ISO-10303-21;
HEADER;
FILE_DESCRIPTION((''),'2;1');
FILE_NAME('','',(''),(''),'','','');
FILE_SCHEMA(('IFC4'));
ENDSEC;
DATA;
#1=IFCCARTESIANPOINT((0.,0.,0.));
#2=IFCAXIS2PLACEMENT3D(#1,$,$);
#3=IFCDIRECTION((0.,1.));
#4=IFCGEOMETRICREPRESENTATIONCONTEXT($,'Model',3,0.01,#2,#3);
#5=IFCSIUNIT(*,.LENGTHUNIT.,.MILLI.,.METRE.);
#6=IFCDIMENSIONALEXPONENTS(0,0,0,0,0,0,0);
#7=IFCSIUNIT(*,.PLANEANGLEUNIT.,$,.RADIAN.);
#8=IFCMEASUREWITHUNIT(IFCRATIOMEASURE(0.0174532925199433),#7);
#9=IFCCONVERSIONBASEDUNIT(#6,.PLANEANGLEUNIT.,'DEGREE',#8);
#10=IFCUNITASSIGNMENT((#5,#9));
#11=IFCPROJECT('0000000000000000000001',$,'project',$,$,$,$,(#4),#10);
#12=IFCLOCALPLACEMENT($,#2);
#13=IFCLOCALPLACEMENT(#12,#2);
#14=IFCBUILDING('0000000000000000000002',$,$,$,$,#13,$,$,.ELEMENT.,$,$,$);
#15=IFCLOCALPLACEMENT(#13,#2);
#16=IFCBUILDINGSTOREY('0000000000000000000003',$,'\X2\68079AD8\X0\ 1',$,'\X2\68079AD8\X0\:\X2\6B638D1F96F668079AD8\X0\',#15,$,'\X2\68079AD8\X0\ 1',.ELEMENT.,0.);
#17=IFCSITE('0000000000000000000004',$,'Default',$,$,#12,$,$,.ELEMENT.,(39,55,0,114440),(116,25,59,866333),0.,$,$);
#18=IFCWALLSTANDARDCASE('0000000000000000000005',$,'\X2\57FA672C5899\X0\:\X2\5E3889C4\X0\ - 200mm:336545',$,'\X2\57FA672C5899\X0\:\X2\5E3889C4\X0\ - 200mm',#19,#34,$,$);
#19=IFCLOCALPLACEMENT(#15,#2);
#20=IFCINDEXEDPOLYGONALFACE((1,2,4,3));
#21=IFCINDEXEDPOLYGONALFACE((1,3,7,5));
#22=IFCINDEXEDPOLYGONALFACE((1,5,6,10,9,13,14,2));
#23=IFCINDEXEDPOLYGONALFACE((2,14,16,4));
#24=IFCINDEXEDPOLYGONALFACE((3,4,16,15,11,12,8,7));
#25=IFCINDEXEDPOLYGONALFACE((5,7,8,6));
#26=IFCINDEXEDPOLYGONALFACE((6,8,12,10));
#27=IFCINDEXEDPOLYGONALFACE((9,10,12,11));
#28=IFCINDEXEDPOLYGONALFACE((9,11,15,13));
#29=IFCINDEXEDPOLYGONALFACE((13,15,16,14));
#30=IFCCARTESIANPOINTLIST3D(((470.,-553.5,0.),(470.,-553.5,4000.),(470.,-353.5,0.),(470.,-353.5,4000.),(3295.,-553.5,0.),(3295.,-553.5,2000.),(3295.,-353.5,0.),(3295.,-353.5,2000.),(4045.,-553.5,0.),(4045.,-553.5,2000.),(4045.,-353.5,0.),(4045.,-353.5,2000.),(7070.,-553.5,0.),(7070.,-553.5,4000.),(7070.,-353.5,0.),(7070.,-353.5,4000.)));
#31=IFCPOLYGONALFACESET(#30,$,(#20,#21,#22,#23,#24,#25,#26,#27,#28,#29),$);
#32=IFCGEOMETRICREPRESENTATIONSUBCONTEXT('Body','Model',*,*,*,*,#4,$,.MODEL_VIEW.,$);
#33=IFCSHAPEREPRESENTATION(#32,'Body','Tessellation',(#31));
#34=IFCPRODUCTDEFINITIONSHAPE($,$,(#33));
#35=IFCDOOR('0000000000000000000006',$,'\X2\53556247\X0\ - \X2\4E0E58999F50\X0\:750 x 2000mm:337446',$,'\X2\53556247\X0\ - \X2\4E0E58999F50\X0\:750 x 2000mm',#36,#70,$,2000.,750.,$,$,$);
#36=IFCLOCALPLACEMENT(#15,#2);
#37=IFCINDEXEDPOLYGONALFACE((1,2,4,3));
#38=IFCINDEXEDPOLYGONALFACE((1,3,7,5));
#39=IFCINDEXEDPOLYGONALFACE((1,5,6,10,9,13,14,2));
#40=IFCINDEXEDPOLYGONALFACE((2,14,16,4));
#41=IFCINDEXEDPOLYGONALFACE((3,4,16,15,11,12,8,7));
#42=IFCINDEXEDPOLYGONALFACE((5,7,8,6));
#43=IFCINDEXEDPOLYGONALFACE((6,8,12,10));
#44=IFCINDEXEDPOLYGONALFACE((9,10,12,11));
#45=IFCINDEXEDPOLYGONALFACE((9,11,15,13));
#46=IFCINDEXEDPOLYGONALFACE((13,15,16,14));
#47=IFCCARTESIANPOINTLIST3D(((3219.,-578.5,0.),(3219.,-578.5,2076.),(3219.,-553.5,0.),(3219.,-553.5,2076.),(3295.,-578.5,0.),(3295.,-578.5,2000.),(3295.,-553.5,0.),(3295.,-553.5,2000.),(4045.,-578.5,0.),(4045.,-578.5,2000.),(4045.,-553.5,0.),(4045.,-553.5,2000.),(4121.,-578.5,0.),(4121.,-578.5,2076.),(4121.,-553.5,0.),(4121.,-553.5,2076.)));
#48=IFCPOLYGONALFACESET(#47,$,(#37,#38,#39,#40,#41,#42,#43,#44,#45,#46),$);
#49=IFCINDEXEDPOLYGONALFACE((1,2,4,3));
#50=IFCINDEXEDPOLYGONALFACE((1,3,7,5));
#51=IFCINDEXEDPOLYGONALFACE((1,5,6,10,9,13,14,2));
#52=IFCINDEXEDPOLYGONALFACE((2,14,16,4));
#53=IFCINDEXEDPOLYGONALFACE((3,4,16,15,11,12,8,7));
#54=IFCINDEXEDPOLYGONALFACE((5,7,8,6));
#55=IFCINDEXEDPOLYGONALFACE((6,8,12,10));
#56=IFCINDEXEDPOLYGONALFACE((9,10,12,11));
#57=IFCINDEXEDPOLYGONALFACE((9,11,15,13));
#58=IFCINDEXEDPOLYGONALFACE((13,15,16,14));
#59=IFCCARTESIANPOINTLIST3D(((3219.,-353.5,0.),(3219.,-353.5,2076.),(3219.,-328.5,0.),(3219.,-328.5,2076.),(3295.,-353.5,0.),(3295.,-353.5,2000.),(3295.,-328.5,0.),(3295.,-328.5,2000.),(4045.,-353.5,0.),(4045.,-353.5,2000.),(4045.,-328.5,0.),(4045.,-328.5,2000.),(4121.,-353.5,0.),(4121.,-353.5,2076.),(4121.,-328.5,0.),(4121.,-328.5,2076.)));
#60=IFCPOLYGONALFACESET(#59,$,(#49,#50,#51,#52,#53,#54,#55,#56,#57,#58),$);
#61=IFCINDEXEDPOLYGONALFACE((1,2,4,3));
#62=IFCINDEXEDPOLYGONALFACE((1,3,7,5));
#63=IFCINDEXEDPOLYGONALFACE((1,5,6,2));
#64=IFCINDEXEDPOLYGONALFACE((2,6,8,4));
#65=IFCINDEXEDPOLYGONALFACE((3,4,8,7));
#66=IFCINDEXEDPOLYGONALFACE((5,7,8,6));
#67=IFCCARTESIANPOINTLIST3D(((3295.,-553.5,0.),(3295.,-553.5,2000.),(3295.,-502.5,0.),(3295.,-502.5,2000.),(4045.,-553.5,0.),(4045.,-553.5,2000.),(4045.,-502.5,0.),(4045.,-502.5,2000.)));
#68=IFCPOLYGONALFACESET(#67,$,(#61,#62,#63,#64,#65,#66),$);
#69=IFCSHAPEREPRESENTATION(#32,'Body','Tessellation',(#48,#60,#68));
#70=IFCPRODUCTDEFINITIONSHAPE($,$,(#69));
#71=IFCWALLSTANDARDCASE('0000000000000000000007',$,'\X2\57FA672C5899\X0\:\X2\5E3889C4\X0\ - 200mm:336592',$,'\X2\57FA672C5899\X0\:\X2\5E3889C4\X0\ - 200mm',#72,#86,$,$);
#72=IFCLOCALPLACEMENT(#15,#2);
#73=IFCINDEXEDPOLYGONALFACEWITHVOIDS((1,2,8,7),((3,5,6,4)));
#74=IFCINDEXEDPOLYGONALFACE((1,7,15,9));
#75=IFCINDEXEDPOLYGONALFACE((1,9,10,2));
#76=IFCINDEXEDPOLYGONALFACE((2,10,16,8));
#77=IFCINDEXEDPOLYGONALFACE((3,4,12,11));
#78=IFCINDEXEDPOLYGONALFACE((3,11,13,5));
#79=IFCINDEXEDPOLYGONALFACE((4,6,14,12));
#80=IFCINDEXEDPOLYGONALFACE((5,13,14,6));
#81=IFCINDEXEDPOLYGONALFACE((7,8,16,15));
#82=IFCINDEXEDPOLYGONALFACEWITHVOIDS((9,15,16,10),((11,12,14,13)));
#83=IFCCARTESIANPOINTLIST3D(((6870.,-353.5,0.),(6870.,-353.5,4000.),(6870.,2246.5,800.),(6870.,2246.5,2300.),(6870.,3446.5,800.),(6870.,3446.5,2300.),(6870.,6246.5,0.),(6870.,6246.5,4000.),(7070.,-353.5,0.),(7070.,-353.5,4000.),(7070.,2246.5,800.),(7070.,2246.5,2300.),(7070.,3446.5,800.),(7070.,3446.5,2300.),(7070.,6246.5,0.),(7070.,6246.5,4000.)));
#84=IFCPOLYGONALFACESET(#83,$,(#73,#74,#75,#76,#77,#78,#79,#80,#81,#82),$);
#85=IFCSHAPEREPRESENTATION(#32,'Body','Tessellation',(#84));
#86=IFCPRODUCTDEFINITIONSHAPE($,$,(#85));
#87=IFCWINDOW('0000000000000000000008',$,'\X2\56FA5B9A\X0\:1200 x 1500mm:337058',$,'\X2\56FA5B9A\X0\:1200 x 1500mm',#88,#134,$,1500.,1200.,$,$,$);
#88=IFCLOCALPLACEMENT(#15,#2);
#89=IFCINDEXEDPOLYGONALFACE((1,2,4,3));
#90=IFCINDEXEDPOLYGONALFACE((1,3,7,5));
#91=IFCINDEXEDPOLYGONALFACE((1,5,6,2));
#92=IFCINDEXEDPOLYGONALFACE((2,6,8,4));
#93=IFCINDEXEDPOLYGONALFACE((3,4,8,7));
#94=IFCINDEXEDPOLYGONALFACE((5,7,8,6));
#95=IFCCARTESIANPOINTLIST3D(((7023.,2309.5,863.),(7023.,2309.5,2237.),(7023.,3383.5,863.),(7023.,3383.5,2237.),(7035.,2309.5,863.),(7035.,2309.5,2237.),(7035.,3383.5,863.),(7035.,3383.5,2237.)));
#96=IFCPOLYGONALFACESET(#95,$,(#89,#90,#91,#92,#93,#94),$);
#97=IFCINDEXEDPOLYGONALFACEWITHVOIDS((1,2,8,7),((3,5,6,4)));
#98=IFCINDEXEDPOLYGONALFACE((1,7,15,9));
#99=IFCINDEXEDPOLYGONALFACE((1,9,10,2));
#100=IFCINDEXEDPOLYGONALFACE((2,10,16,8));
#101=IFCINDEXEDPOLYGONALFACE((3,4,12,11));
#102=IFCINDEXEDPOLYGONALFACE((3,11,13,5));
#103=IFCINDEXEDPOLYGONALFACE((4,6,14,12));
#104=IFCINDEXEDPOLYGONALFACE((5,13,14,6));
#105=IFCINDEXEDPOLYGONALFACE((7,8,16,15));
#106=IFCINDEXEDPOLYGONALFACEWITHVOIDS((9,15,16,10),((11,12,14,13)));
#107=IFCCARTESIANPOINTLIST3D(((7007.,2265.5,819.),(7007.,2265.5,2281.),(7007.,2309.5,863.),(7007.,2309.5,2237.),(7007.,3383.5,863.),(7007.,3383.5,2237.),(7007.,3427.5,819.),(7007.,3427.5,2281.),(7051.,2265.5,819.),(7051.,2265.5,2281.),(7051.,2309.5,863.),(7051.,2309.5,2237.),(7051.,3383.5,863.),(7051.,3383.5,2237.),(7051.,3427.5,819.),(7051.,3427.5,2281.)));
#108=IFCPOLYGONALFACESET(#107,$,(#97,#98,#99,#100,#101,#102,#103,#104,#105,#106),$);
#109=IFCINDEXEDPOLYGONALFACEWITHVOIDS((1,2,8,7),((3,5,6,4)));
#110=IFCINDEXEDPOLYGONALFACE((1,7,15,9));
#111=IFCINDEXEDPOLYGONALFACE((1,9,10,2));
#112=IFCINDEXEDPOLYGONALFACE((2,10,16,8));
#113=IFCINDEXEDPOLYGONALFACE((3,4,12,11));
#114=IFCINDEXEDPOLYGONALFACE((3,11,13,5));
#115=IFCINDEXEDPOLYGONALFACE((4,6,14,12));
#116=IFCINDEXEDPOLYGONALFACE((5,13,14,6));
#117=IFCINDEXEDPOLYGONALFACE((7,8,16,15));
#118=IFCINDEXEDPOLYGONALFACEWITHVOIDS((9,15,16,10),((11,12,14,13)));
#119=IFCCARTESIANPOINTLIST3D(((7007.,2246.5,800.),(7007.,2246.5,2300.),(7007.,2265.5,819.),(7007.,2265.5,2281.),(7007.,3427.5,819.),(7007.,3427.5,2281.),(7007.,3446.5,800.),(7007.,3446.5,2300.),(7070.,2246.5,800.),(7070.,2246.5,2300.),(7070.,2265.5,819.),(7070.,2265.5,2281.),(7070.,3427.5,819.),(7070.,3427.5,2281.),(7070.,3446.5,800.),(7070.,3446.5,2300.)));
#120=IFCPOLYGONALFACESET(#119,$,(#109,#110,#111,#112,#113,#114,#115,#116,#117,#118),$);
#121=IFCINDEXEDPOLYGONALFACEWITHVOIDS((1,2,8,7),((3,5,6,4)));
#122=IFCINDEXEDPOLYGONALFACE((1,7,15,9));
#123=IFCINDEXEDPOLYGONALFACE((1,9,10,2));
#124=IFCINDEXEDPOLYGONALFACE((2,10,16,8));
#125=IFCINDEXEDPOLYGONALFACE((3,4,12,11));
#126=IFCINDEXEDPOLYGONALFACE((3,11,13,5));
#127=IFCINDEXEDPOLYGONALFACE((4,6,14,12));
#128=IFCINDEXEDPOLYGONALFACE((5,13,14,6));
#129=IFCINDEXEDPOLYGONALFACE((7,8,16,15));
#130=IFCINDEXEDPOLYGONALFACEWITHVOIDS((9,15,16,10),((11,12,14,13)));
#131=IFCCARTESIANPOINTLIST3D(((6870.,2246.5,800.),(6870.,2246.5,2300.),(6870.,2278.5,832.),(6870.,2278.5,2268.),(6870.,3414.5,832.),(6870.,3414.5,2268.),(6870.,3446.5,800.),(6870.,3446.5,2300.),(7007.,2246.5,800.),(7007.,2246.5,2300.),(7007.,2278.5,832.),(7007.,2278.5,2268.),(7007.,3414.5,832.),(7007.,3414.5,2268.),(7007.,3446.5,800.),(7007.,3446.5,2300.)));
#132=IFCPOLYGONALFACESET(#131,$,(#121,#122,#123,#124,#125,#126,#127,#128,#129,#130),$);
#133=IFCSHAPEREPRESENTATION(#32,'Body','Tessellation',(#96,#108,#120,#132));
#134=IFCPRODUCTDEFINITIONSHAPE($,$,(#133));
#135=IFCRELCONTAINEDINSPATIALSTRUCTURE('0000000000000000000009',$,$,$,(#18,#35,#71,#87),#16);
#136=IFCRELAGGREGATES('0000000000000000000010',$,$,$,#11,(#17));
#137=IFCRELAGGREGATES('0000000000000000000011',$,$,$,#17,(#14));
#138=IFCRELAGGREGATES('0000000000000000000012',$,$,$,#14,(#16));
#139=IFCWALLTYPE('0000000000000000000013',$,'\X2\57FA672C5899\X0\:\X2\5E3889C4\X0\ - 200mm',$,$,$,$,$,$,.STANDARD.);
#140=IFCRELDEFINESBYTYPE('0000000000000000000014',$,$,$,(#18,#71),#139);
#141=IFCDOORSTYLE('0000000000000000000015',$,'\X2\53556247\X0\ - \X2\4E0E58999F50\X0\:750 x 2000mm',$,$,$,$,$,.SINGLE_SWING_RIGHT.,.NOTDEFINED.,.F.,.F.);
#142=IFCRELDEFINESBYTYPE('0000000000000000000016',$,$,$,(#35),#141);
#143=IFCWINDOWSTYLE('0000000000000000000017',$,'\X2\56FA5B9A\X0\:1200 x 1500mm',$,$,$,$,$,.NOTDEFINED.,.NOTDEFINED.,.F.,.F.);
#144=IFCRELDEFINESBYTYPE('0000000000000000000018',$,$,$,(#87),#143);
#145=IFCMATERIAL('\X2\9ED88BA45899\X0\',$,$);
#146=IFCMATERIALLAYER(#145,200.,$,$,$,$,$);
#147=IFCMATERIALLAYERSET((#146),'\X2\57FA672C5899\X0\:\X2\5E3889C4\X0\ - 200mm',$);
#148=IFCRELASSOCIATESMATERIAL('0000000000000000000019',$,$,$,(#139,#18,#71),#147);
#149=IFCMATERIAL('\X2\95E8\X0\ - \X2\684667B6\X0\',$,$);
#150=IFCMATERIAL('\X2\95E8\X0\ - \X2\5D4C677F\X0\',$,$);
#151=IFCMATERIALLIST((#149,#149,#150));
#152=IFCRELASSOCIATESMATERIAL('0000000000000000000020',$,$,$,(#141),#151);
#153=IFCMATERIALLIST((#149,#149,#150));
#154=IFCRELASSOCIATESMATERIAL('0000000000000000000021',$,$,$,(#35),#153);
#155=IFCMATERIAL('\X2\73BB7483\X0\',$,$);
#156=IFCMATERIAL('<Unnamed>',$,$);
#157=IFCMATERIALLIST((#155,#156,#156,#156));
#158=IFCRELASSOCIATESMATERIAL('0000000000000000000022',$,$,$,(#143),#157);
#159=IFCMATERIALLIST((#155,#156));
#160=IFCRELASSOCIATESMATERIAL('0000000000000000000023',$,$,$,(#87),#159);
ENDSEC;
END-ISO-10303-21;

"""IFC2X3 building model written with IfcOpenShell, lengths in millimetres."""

from ifc_helpers import new_model, entity, si_unit, converted_unit, direction, frame, frame_2d, origin, place, context, subcontext, project, spatial, polyline, rectangle, outline, extrude, source, transform, mapped, material, material_list, layer, layer_set, layer_usage, type_object, type_shapes, element, fill, save


model = new_model("IFC2X3")

# Units and contexts
model_context = context("Model", 3, precision=0.01, world=origin(), true_north=direction((0.0, 1.0)))
body_context = subcontext(model_context, "Body", "Model", "MODEL_VIEW")
ifc_project = project(units=[si_unit("LENGTHUNIT", "METRE", prefix="MILLI"), converted_unit("PLANEANGLEUNIT", "DEGREE", entity("IfcRatioMeasure", 0.0174532925199433), si_unit("PLANEANGLEUNIT", "RADIAN"), dimensions=[0, 0, 0, 0, 0, 0, 0])], contexts=[model_context])

# Site, building, storey
site_placement = place(None, origin())
site = spatial("IfcSite", under=ifc_project, at=site_placement, Name="Default", CompositionType="ELEMENT", RefLatitude=(39, 55, 0, 114440), RefLongitude=(116, 25, 59, 866333), RefElevation=0.0)
building_placement = place(site_placement, origin())
building = spatial("IfcBuilding", under=site, at=building_placement, CompositionType="ELEMENT")
storey_placement = place(building_placement, origin())
storey = spatial("IfcBuildingStorey", under=building, at=storey_placement, Name="标高 1", ObjectType="标高:正负零标高", LongName="标高 1", CompositionType="ELEMENT", Elevation=0.0)

# Shared definitions
ifc_material_1 = material(Name="默认墙")
ifc_layer = layer(ifc_material_1, 200.0)
ifc_layer_set = layer_set([ifc_layer], Name="基本墙:常规 - 200mm")
wall_type = type_object("IfcWallType", Name="基本墙:常规 - 200mm", PredefinedType="STANDARD", material=ifc_layer_set)
ifc_material_2 = material(Name="玻璃")
ifc_material_3 = material(Name="<Unnamed>")
ifc_material_4 = material(Name="门 - 框架")
ifc_material_5 = material(Name="门 - 嵌板")

# Wall, opening, door
ifc_layer_usage_1 = layer_usage(ifc_layer_set, "AXIS2", "NEGATIVE", 100.0)
wall_1_placement = place(storey_placement, frame((470.0, -453.5, 0.0)))
wall_1 = element("IfcWallStandardCase", 1, at=wall_1_placement, inside=storey, type_object=wall_type, material=ifc_layer_usage_1, Name="基本墙:常规 - 200mm:336545", ObjectType="基本墙:常规 - 200mm", context=body_context, shape_type="SweptSolid", body=[
    extrude(rectangle(XDim=6600.0, YDim=200.0, at=frame_2d((3300.0, 0.0), x_axis=(-1.0, 0.0))), origin(), (0.0, 0.0, 1.0), 4000.0),
])
opening_1_placement = place(wall_1_placement, frame((3575.0, 100.0, 0.0)))
opening_1 = element("IfcOpeningElement", 2, at=opening_1_placement, cuts=wall_1, ObjectType="Opening", context=body_context, shape_type="SweptSolid", body=[
    extrude(rectangle(XDim=750.0, YDim=2000.0, at=frame_2d((1000.0, 375.0), x_axis=(0.0, 1.0))), frame((0.0, 0.0, 0.0), z_axis=(0.0, -1.0, 0.0), x_axis=(0.0, 0.0, 1.0)), (0.0, 0.0, 1.0), 200.0),
])
ifc_material_list_1 = material_list([ifc_material_4, ifc_material_4, ifc_material_5])
ifc_material_list_2 = material_list([ifc_material_4, ifc_material_4, ifc_material_5])
door_style_1 = type_object("IfcDoorStyle", Name="单扇 - 与墙齐:750 x 2000mm", ConstructionType="NOTDEFINED", OperationType="SINGLE_SWING_RIGHT", ParameterTakesPrecedence=False, Sizeable=False, material=ifc_material_list_2)
shared_shape_1 = source(origin(), body_context, "Body", "SweptSolid", [
    extrude(outline(polyline([(-451.0, -1057.0), (451.0, -1057.0), (451.0, 1019.0), (375.0, 1019.0), (375.0, -981.0), (-375.0, -981.0), (-375.0, 1019.0), (-451.0, 1019.0), (-451.0, -1057.0)])), frame((375.0, 200.0, 1019.0), z_axis=(0.0, 1.0, 0.0), x_axis=(1.0, 0.0, 0.0)), (0.0, 0.0, 1.0), 25.0),
    extrude(outline(polyline([(-1057.0, -451.0), (1019.0, -451.0), (1019.0, -375.0), (-981.0, -375.0), (-981.0, 375.0), (1019.0, 375.0), (1019.0, 451.0), (-1057.0, 451.0), (-1057.0, -451.0)])), frame((375.0, -25.0, 1019.0), z_axis=(0.0, 1.0, 0.0), x_axis=(0.0, 0.0, -1.0)), (0.0, 0.0, 1.0), 25.0),
    extrude(rectangle(XDim=51.0, YDim=750.0, at=frame_2d((0.0, 0.0), x_axis=(1.0, 0.0))), frame((375.0, 174.5, 0.0), z_axis=(0.0, 0.0, 1.0), x_axis=(0.0, 1.0, 0.0)), (0.0, 0.0, 1.0), 2000.0),
])
type_shapes(door_style_1, [shared_shape_1])
door_1_placement = place(opening_1_placement, frame((0.0, 0.0, 0.0), z_axis=(0.0, 0.0, 1.0), x_axis=(-1.0, 0.0, 0.0)))
door_1 = element("IfcDoor", 3, at=door_1_placement, inside=storey, type_object=door_style_1, material=ifc_material_list_1, Name="单扇 - 与墙齐:750 x 2000mm:337446", ObjectType="单扇 - 与墙齐:750 x 2000mm", OverallHeight=2000.0, OverallWidth=750.0, context=body_context, shape_type="MappedRepresentation", body=[
    mapped(shared_shape_1, transform((0.0, 0.0, 0.0), scale=1.0)),
])
fill(opening_1, door_1)

# Wall, opening, window
ifc_layer_usage_2 = layer_usage(ifc_layer_set, "AXIS2", "NEGATIVE", 100.0)
wall_2_placement = place(storey_placement, frame((6970.0, -353.5, 0.0), z_axis=(0.0, 0.0, 1.0), x_axis=(0.0, 1.0, 0.0)))
wall_2 = element("IfcWallStandardCase", 4, at=wall_2_placement, inside=storey, type_object=wall_type, material=ifc_layer_usage_2, Name="基本墙:常规 - 200mm:336592", ObjectType="基本墙:常规 - 200mm", context=body_context, shape_type="SweptSolid", body=[
    extrude(rectangle(XDim=6600.0, YDim=200.0, at=frame_2d((3300.0, 0.0), x_axis=(-1.0, 0.0))), origin(), (0.0, 0.0, 1.0), 4000.0),
])
opening_2_placement = place(wall_2_placement, frame((3800.0, 100.0, 800.0)))
opening_2 = element("IfcOpeningElement", 5, at=opening_2_placement, cuts=wall_2, ObjectType="Opening", context=body_context, shape_type="SweptSolid", body=[
    extrude(rectangle(XDim=1500.0, YDim=1200.0, at=frame_2d((750.0, 600.0), x_axis=(1.0, 0.0))), frame((0.0, 0.0, 0.0), z_axis=(0.0, -1.0, 0.0), x_axis=(0.0, 0.0, 1.0)), (0.0, 0.0, 1.0), 200.0),
])
ifc_material_list_3 = material_list([ifc_material_2, ifc_material_3])
ifc_material_list_4 = material_list([ifc_material_2, ifc_material_3, ifc_material_3, ifc_material_3])
window_style_1 = type_object("IfcWindowStyle", Name="固定:1200 x 1500mm", ConstructionType="NOTDEFINED", OperationType="NOTDEFINED", ParameterTakesPrecedence=False, Sizeable=False, material=ifc_material_list_4)
shared_shape_2 = source(origin(), body_context, "Body", "SweptSolid", [
    extrude(rectangle(XDim=12.0, YDim=1074.0, at=frame_2d((0.0, 0.0), x_axis=(1.0, 0.0))), frame((600.0, 159.0, 63.0), z_axis=(0.0, 0.0, 1.0), x_axis=(0.0, -1.0, 0.0)), (0.0, 0.0, 1.0), 1374.0),
    extrude(outline(polyline([(-581.0, -731.0), (581.0, -731.0), (581.0, 731.0), (-581.0, 731.0), (-581.0, -731.0)]), holes=[polyline([(-537.0, -687.0), (-537.0, 687.0), (537.0, 687.0), (537.0, -687.0), (-537.0, -687.0)])]), frame((600.0, 137.0, 750.0), z_axis=(0.0, 1.0, 0.0), x_axis=(1.0, 0.0, 0.0)), (0.0, 0.0, 1.0), 44.0),
    extrude(outline(polyline([(-600.0, -750.0), (600.0, -750.0), (600.0, 750.0), (-600.0, 750.0), (-600.0, -750.0)]), holes=[polyline([(-581.0, -731.0), (-581.0, 731.0), (581.0, 731.0), (581.0, -731.0), (-581.0, -731.0)])]), frame((600.0, 137.0, 750.0), z_axis=(0.0, 1.0, 0.0), x_axis=(1.0, 0.0, 0.0)), (0.0, 0.0, 1.0), 63.0),
    extrude(outline(polyline([(-600.0, -750.0), (600.0, -750.0), (600.0, 750.0), (-600.0, 750.0), (-600.0, -750.0)]), holes=[polyline([(-568.0, -718.0), (-568.0, 718.0), (568.0, 718.0), (568.0, -718.0), (-568.0, -718.0)])]), frame((600.0, 0.0, 750.0), z_axis=(0.0, 1.0, 0.0), x_axis=(1.0, 0.0, 0.0)), (0.0, 0.0, 1.0), 137.0),
])
type_shapes(window_style_1, [shared_shape_2])
window_1_placement = place(opening_2_placement, frame((0.0, 0.0, 0.0), z_axis=(0.0, 0.0, 1.0), x_axis=(-1.0, 0.0, 0.0)))
window_1 = element("IfcWindow", 6, at=window_1_placement, inside=storey, type_object=window_style_1, material=ifc_material_list_3, Name="固定:1200 x 1500mm:337058", ObjectType="固定:1200 x 1500mm", OverallHeight=1500.0, OverallWidth=1200.0, context=body_context, shape_type="MappedRepresentation", body=[
    mapped(shared_shape_2, transform((0.0, 0.0, 0.0), scale=1.0)),
])
fill(opening_2, window_1)

save(model, "model.ifc")
